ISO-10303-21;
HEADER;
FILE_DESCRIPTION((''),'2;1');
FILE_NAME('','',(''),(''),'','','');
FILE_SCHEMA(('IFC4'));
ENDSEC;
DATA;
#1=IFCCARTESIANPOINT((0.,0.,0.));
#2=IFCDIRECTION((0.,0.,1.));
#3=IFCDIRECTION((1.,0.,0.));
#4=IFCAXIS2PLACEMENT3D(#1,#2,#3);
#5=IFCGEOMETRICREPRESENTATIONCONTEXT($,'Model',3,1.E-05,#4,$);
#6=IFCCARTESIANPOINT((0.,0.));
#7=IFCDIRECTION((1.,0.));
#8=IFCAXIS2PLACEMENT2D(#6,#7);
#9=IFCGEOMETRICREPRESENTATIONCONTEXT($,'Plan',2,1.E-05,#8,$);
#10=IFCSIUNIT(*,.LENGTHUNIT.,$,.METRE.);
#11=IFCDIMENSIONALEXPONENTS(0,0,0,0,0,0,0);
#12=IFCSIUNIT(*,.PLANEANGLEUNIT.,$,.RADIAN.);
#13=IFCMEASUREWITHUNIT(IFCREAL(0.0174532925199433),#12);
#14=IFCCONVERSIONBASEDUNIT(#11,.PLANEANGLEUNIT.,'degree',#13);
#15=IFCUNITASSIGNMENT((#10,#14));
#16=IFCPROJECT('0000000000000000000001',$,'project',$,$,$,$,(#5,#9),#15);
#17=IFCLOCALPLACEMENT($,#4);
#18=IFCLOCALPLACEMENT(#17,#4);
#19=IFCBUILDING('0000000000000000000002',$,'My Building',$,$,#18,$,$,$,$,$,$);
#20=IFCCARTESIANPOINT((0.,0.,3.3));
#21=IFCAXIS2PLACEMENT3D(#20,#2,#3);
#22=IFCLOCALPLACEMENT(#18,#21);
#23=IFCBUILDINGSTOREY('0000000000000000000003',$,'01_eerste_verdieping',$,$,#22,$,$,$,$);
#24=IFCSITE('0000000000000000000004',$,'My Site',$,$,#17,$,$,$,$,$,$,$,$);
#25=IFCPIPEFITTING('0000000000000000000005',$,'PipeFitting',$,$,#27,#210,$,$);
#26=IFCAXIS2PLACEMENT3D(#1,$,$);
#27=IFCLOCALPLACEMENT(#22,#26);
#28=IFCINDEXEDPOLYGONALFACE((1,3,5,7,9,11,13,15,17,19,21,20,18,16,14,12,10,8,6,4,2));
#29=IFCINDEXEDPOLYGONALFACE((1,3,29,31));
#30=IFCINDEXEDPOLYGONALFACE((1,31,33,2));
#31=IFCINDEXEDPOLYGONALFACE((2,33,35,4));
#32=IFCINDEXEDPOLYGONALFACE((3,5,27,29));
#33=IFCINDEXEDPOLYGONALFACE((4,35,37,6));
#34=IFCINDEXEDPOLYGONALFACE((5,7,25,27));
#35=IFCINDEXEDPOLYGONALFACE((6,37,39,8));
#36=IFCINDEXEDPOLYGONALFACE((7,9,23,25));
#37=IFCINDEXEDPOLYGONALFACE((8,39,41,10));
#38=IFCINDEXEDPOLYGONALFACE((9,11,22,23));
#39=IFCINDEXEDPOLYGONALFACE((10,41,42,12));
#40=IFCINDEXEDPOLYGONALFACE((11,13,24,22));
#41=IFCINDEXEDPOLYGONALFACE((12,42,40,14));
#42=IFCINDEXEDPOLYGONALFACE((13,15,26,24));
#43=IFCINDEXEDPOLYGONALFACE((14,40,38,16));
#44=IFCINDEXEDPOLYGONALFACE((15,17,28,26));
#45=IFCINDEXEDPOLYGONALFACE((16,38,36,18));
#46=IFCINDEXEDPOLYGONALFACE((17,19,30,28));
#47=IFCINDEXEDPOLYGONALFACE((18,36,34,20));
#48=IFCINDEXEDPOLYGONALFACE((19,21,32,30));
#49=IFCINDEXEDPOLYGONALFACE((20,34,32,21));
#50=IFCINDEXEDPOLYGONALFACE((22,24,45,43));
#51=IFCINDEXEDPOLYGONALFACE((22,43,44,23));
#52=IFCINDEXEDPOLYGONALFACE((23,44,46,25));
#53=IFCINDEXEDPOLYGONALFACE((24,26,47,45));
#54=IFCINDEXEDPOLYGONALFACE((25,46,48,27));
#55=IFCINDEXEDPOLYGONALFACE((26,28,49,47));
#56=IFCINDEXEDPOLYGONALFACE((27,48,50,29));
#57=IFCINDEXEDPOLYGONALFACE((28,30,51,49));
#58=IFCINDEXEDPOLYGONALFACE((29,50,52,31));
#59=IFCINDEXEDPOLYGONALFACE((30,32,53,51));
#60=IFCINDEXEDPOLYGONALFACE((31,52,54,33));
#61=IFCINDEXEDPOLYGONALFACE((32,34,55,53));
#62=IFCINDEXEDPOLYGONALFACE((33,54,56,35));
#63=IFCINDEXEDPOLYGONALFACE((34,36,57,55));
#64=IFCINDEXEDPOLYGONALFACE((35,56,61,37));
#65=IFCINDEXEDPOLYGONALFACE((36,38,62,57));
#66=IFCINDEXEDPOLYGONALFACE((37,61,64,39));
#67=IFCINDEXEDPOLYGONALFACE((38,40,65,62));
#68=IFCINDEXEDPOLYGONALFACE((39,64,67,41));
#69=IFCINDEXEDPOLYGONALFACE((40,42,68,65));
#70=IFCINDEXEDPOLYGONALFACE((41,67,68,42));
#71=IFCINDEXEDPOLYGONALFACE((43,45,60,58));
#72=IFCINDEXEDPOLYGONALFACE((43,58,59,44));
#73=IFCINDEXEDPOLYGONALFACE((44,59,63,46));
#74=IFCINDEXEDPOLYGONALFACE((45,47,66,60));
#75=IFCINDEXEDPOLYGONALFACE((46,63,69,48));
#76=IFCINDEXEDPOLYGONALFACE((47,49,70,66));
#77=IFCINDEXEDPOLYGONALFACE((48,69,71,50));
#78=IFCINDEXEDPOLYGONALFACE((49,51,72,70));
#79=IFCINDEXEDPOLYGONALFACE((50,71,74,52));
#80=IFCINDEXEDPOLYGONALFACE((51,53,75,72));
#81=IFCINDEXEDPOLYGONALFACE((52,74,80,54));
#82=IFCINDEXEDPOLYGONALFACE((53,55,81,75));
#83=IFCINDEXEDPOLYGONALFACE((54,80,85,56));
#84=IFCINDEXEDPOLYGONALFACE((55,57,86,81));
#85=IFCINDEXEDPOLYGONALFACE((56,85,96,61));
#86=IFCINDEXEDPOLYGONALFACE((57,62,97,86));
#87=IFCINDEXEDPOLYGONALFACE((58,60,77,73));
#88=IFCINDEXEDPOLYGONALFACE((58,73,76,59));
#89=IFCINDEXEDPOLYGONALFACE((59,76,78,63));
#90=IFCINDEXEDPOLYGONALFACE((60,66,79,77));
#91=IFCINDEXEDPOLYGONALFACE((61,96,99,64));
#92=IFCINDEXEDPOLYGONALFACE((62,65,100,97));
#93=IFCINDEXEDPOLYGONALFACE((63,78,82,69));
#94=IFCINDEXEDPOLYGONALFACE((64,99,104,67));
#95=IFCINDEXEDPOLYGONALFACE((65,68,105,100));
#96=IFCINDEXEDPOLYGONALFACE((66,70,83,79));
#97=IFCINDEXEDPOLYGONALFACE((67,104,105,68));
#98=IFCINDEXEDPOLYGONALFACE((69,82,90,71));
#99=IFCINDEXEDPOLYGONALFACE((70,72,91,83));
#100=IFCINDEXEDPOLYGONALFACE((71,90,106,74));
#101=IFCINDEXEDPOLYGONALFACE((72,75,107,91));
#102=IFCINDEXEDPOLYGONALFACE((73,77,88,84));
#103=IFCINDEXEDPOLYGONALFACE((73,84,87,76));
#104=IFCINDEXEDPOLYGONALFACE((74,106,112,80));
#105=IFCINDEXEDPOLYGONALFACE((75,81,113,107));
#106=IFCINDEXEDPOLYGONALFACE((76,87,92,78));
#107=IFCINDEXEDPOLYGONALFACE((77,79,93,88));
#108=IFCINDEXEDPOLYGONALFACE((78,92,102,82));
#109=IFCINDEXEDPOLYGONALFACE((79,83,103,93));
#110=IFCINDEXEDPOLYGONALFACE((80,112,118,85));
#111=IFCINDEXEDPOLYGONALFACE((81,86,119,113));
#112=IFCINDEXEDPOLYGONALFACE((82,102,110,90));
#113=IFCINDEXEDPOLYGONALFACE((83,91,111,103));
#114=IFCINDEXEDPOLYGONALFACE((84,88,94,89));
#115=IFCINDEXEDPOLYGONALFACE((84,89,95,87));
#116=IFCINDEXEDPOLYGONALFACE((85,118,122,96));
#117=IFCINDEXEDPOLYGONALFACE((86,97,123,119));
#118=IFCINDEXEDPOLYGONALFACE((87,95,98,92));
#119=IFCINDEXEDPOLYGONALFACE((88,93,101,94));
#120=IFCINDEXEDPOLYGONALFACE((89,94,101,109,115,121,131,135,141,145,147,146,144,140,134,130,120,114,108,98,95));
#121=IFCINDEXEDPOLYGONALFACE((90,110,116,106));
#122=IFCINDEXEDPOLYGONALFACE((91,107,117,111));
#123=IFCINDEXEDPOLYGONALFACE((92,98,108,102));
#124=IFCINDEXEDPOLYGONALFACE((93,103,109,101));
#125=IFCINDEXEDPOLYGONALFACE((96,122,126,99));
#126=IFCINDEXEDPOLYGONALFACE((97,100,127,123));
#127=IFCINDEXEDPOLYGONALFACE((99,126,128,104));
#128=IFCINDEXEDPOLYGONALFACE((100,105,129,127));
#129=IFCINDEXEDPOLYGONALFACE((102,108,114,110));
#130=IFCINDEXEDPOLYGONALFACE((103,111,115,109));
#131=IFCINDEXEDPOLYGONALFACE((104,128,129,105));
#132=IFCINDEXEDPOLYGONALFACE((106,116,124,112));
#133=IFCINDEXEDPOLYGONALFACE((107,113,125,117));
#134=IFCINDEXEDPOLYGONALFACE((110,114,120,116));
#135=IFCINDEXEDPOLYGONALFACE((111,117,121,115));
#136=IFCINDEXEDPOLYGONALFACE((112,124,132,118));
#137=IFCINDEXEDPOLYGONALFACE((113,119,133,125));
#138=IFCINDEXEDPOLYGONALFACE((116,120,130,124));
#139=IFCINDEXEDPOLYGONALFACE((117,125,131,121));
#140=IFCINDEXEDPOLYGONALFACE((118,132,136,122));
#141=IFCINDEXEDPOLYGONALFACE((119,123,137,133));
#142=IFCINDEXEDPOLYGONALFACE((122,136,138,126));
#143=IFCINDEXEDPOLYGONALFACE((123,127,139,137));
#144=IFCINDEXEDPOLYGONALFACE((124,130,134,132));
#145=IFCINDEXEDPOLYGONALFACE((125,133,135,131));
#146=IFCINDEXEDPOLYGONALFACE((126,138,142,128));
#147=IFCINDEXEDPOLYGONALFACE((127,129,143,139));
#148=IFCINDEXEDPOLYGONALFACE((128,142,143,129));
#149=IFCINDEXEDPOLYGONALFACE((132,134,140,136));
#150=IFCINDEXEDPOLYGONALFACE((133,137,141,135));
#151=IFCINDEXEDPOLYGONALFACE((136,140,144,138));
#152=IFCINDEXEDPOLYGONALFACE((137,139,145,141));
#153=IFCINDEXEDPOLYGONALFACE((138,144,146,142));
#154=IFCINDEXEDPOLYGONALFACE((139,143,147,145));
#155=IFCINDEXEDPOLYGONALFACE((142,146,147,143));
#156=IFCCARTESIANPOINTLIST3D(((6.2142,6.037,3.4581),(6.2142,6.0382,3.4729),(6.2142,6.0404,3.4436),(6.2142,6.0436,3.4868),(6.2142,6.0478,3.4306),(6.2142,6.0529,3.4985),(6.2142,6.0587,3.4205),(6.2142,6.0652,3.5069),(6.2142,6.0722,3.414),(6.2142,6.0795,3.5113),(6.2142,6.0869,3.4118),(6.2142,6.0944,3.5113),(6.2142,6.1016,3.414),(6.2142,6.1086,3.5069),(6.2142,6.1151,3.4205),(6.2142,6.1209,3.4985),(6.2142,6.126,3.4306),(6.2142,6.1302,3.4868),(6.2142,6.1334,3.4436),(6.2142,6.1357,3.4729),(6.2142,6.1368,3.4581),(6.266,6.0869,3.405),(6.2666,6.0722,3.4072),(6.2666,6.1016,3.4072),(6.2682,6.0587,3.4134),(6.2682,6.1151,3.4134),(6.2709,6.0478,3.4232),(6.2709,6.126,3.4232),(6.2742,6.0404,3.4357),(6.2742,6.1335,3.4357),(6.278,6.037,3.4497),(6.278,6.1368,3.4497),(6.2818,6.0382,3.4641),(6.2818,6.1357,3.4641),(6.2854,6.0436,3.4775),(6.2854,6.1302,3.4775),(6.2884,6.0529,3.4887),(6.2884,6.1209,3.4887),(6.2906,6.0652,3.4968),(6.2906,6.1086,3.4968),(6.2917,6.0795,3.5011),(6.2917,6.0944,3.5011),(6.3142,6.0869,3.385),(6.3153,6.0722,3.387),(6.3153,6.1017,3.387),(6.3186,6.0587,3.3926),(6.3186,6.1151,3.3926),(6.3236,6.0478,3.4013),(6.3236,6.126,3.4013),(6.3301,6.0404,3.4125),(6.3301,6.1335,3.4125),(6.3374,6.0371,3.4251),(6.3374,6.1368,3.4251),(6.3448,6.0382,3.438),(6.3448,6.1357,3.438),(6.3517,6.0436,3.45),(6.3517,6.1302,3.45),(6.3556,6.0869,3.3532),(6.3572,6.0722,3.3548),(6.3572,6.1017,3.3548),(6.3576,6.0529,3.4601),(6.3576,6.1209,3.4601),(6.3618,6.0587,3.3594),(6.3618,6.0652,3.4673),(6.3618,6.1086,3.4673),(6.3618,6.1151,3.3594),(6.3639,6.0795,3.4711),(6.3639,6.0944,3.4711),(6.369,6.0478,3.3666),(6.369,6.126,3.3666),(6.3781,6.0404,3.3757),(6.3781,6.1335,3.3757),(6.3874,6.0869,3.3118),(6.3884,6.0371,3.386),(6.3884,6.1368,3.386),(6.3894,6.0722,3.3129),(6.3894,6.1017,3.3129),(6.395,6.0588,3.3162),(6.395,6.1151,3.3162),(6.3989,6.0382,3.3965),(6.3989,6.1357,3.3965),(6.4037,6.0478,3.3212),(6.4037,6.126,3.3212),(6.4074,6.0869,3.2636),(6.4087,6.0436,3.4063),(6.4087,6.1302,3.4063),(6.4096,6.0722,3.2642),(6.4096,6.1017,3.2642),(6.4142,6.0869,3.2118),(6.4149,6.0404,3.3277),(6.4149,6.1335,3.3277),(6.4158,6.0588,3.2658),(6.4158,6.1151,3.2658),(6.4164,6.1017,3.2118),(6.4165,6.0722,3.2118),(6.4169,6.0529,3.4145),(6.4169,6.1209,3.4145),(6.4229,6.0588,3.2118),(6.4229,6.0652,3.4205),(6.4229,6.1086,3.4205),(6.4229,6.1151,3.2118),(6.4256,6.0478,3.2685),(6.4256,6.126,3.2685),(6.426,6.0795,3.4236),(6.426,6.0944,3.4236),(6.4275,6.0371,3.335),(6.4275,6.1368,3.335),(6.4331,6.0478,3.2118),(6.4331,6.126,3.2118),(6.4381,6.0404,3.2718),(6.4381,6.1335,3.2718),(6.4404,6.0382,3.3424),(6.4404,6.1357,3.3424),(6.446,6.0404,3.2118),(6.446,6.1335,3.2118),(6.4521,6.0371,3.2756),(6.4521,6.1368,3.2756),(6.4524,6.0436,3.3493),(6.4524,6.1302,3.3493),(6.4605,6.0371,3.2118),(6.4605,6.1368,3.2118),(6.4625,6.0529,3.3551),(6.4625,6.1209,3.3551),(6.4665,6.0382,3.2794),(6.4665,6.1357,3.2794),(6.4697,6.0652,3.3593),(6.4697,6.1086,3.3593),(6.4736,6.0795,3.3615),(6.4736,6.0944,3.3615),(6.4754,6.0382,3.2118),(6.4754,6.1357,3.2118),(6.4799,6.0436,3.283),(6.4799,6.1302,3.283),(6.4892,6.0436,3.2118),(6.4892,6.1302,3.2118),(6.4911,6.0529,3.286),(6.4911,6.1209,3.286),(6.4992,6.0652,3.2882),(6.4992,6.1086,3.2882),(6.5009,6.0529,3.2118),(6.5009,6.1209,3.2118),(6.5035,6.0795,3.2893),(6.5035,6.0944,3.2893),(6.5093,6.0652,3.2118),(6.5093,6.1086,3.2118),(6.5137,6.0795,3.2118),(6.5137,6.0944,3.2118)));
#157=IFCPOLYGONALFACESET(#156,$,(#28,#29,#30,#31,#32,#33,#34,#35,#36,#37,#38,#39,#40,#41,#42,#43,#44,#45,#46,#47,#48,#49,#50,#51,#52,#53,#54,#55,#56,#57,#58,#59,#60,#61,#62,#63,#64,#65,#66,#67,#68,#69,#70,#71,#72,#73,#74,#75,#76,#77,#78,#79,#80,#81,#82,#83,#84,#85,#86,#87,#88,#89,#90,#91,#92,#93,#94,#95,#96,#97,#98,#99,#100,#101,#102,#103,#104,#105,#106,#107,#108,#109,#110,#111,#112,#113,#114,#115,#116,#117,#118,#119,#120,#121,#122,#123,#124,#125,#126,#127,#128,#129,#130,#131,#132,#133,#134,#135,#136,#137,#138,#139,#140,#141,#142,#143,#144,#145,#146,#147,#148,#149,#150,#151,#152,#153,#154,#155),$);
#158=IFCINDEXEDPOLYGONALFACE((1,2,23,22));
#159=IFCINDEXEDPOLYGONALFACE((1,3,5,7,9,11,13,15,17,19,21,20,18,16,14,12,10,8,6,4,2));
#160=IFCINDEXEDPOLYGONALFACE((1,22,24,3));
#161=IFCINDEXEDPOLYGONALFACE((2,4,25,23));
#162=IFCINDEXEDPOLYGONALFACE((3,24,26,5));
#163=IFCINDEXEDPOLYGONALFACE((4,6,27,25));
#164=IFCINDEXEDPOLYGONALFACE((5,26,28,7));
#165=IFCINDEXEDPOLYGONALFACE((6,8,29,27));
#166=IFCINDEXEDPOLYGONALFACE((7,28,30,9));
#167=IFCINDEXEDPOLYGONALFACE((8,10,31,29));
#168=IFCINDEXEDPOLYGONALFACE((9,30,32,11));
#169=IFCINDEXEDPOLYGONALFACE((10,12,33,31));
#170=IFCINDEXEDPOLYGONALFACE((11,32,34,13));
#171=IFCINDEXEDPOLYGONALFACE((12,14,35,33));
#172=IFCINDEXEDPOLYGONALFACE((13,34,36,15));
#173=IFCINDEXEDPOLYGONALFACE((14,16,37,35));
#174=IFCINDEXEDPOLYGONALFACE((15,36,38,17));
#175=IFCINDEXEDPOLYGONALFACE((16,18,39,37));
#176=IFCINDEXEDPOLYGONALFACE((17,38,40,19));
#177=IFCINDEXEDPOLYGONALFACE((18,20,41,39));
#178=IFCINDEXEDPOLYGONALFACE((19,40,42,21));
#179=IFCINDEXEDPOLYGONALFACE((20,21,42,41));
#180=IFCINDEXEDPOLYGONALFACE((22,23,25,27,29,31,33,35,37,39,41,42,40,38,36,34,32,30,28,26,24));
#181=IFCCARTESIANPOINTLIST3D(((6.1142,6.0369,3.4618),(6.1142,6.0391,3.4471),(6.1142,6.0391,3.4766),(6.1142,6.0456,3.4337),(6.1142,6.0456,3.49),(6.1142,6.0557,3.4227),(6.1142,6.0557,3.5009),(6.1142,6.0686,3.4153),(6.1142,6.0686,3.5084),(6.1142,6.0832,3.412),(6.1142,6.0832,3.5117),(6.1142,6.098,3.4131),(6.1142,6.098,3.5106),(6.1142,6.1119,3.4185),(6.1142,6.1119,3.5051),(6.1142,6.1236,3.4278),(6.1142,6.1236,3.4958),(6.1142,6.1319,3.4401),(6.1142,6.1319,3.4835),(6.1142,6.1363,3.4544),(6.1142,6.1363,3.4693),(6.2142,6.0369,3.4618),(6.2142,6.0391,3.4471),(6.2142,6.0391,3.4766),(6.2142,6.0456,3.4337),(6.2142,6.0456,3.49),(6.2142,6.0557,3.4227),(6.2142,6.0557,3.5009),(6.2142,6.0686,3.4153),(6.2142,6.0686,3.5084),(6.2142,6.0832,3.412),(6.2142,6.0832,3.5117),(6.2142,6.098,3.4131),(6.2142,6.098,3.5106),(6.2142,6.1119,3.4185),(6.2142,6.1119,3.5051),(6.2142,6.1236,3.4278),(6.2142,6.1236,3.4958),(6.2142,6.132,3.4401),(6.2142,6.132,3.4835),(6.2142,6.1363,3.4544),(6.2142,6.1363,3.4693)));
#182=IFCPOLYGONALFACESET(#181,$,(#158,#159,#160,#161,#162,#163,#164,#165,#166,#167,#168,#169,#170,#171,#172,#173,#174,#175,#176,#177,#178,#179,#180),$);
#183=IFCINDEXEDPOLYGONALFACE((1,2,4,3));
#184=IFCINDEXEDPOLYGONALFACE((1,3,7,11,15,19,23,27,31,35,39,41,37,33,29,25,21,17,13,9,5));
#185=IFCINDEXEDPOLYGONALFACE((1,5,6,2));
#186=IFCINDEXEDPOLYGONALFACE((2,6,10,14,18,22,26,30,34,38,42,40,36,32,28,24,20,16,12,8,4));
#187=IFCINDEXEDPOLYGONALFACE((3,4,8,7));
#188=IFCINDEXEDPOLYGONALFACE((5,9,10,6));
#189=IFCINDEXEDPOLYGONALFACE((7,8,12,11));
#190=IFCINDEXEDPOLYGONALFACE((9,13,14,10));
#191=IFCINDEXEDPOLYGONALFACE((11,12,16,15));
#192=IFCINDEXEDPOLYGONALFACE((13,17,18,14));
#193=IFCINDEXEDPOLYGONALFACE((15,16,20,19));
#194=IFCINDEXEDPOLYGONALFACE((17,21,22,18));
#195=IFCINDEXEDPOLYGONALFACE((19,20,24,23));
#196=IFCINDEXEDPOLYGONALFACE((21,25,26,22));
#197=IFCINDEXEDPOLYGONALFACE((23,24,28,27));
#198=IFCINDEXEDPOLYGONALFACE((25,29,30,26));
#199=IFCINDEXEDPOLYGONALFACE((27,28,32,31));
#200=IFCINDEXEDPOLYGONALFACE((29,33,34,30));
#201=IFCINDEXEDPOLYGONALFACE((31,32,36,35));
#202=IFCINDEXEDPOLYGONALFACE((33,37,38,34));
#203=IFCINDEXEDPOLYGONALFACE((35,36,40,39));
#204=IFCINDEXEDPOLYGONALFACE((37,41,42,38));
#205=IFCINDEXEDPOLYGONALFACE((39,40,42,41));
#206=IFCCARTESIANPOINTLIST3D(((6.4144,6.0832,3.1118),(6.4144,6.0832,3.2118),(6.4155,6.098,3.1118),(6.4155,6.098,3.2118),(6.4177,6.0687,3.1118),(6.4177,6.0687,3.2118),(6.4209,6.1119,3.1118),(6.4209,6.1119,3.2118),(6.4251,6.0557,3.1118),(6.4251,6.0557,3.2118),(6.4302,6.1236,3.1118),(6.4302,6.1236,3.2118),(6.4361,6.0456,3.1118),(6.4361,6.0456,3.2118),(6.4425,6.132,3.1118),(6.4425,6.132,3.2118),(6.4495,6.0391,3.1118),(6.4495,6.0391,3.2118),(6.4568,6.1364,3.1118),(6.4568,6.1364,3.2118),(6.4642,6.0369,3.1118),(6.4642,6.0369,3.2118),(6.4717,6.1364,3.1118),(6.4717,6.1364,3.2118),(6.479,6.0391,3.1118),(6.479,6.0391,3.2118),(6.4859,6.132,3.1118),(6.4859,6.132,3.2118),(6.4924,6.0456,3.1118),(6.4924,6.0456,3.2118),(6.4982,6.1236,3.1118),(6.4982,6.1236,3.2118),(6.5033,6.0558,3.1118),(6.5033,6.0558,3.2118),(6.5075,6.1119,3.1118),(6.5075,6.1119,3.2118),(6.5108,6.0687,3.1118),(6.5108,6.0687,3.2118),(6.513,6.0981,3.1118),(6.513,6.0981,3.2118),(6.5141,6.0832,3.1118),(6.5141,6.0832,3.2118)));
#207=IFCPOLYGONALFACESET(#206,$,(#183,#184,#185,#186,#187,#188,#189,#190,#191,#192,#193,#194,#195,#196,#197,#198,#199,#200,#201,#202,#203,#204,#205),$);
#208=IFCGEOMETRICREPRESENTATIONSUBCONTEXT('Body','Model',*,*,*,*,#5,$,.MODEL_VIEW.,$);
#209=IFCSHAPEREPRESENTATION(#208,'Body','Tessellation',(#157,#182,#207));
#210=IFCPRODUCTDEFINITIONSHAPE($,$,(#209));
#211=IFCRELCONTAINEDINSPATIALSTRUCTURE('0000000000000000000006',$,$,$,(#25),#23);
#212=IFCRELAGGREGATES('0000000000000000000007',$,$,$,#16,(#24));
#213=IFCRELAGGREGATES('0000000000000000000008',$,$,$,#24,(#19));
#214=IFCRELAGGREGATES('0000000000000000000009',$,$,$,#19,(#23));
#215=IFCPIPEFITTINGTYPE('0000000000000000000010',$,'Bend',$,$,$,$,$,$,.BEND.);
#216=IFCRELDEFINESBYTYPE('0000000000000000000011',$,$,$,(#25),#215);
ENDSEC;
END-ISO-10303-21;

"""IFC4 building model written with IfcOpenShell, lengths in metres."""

from ifc_helpers import new_model, entity, si_unit, converted_unit, frame, origin_with_axes, origin_2d_with_axis, place, context, subcontext, project, spatial, circle, extrude, source, transform, mapped, type_object, type_shapes, element, save


model = new_model("IFC4")

# Units and contexts
model_context = context("Model", 3, precision=1e-05, world=origin_with_axes())
plan_context = context("Plan", 2, precision=1e-05, world=origin_2d_with_axis())
body_context_1 = subcontext(model_context, "Body", "Model", "MODEL_VIEW")
ifc_project = project(units=[si_unit("LENGTHUNIT", "METRE"), converted_unit("PLANEANGLEUNIT", "degree", entity("IfcReal", 0.0174532925199433), si_unit("PLANEANGLEUNIT", "RADIAN"), dimensions=[0, 0, 0, 0, 0, 0, 0])], contexts=[model_context, plan_context])

# Site, building, storey
site_placement = place(None, origin_with_axes())
site = spatial("IfcSite", under=ifc_project, at=site_placement, Name="My Site")
building_placement = place(site_placement, origin_with_axes())
building = spatial("IfcBuilding", under=site, at=building_placement, Name="My Building")
storey_placement = place(building_placement, frame((0.0, 0.0, 3.3), z_axis=(0.0, 0.0, 1.0), x_axis=(1.0, 0.0, 0.0)))
storey = spatial("IfcBuildingStorey", under=building, at=storey_placement, Name="01_eerste_verdieping")

# Pipe fitting
pipe_fitting_type = type_object("IfcPipeFittingType", Name="Bend", PredefinedType="BEND")
shared_shape_1 = source(origin_with_axes(), body_context_1, "Body", "AdvancedSweptSolid", [
    entity("IfcSweptDiskSolid", entity("IfcIndexedPolyCurve", entity("IfcCartesianPointList3D", [[0.0, 0.0, -0.1], [0.0, -0.0732, -0.2768], [0.0, -0.25, -0.35]]), [entity("IfcArcIndex", [1, 2, 3])]), 0.05),
    extrude(circle(Radius=0.05), origin_with_axes(), (0.0, 0.0, -1.0), 0.1),
    extrude(circle(Radius=0.05), frame((0.0, -0.25, -0.35), z_axis=(0.0, -1.0, 0.0), x_axis=(1.0, 0.0, 0.0)), (0.0, 0.0, 1.0), 0.1),
])
type_shapes(pipe_fitting_type, [shared_shape_1])
for number, where, z_axis, x_axis, name in (
    (1, (6.1142, 6.0869, 3.4618), (-1.0, -0.000073, 0.0), (0.000073, -1.0, 0.0), "PipeFitting"),
):
    element("IfcPipeFitting", number, at=place(storey_placement, frame(where, z_axis=z_axis, x_axis=x_axis)), inside=storey, type_object=pipe_fitting_type, Name=name, context=body_context_1, shape_type="MappedRepresentation", body=[
        mapped(shared_shape_1, transform((0.0, 0.0, 0.0), x_axis=(1.0, 0.0, 0.0), y_axis=(0.0, 1.0, 0.0), z_axis=(0.0, 0.0, 1.0), scale=1.0)),
    ])

save(model, "model.ifc")
